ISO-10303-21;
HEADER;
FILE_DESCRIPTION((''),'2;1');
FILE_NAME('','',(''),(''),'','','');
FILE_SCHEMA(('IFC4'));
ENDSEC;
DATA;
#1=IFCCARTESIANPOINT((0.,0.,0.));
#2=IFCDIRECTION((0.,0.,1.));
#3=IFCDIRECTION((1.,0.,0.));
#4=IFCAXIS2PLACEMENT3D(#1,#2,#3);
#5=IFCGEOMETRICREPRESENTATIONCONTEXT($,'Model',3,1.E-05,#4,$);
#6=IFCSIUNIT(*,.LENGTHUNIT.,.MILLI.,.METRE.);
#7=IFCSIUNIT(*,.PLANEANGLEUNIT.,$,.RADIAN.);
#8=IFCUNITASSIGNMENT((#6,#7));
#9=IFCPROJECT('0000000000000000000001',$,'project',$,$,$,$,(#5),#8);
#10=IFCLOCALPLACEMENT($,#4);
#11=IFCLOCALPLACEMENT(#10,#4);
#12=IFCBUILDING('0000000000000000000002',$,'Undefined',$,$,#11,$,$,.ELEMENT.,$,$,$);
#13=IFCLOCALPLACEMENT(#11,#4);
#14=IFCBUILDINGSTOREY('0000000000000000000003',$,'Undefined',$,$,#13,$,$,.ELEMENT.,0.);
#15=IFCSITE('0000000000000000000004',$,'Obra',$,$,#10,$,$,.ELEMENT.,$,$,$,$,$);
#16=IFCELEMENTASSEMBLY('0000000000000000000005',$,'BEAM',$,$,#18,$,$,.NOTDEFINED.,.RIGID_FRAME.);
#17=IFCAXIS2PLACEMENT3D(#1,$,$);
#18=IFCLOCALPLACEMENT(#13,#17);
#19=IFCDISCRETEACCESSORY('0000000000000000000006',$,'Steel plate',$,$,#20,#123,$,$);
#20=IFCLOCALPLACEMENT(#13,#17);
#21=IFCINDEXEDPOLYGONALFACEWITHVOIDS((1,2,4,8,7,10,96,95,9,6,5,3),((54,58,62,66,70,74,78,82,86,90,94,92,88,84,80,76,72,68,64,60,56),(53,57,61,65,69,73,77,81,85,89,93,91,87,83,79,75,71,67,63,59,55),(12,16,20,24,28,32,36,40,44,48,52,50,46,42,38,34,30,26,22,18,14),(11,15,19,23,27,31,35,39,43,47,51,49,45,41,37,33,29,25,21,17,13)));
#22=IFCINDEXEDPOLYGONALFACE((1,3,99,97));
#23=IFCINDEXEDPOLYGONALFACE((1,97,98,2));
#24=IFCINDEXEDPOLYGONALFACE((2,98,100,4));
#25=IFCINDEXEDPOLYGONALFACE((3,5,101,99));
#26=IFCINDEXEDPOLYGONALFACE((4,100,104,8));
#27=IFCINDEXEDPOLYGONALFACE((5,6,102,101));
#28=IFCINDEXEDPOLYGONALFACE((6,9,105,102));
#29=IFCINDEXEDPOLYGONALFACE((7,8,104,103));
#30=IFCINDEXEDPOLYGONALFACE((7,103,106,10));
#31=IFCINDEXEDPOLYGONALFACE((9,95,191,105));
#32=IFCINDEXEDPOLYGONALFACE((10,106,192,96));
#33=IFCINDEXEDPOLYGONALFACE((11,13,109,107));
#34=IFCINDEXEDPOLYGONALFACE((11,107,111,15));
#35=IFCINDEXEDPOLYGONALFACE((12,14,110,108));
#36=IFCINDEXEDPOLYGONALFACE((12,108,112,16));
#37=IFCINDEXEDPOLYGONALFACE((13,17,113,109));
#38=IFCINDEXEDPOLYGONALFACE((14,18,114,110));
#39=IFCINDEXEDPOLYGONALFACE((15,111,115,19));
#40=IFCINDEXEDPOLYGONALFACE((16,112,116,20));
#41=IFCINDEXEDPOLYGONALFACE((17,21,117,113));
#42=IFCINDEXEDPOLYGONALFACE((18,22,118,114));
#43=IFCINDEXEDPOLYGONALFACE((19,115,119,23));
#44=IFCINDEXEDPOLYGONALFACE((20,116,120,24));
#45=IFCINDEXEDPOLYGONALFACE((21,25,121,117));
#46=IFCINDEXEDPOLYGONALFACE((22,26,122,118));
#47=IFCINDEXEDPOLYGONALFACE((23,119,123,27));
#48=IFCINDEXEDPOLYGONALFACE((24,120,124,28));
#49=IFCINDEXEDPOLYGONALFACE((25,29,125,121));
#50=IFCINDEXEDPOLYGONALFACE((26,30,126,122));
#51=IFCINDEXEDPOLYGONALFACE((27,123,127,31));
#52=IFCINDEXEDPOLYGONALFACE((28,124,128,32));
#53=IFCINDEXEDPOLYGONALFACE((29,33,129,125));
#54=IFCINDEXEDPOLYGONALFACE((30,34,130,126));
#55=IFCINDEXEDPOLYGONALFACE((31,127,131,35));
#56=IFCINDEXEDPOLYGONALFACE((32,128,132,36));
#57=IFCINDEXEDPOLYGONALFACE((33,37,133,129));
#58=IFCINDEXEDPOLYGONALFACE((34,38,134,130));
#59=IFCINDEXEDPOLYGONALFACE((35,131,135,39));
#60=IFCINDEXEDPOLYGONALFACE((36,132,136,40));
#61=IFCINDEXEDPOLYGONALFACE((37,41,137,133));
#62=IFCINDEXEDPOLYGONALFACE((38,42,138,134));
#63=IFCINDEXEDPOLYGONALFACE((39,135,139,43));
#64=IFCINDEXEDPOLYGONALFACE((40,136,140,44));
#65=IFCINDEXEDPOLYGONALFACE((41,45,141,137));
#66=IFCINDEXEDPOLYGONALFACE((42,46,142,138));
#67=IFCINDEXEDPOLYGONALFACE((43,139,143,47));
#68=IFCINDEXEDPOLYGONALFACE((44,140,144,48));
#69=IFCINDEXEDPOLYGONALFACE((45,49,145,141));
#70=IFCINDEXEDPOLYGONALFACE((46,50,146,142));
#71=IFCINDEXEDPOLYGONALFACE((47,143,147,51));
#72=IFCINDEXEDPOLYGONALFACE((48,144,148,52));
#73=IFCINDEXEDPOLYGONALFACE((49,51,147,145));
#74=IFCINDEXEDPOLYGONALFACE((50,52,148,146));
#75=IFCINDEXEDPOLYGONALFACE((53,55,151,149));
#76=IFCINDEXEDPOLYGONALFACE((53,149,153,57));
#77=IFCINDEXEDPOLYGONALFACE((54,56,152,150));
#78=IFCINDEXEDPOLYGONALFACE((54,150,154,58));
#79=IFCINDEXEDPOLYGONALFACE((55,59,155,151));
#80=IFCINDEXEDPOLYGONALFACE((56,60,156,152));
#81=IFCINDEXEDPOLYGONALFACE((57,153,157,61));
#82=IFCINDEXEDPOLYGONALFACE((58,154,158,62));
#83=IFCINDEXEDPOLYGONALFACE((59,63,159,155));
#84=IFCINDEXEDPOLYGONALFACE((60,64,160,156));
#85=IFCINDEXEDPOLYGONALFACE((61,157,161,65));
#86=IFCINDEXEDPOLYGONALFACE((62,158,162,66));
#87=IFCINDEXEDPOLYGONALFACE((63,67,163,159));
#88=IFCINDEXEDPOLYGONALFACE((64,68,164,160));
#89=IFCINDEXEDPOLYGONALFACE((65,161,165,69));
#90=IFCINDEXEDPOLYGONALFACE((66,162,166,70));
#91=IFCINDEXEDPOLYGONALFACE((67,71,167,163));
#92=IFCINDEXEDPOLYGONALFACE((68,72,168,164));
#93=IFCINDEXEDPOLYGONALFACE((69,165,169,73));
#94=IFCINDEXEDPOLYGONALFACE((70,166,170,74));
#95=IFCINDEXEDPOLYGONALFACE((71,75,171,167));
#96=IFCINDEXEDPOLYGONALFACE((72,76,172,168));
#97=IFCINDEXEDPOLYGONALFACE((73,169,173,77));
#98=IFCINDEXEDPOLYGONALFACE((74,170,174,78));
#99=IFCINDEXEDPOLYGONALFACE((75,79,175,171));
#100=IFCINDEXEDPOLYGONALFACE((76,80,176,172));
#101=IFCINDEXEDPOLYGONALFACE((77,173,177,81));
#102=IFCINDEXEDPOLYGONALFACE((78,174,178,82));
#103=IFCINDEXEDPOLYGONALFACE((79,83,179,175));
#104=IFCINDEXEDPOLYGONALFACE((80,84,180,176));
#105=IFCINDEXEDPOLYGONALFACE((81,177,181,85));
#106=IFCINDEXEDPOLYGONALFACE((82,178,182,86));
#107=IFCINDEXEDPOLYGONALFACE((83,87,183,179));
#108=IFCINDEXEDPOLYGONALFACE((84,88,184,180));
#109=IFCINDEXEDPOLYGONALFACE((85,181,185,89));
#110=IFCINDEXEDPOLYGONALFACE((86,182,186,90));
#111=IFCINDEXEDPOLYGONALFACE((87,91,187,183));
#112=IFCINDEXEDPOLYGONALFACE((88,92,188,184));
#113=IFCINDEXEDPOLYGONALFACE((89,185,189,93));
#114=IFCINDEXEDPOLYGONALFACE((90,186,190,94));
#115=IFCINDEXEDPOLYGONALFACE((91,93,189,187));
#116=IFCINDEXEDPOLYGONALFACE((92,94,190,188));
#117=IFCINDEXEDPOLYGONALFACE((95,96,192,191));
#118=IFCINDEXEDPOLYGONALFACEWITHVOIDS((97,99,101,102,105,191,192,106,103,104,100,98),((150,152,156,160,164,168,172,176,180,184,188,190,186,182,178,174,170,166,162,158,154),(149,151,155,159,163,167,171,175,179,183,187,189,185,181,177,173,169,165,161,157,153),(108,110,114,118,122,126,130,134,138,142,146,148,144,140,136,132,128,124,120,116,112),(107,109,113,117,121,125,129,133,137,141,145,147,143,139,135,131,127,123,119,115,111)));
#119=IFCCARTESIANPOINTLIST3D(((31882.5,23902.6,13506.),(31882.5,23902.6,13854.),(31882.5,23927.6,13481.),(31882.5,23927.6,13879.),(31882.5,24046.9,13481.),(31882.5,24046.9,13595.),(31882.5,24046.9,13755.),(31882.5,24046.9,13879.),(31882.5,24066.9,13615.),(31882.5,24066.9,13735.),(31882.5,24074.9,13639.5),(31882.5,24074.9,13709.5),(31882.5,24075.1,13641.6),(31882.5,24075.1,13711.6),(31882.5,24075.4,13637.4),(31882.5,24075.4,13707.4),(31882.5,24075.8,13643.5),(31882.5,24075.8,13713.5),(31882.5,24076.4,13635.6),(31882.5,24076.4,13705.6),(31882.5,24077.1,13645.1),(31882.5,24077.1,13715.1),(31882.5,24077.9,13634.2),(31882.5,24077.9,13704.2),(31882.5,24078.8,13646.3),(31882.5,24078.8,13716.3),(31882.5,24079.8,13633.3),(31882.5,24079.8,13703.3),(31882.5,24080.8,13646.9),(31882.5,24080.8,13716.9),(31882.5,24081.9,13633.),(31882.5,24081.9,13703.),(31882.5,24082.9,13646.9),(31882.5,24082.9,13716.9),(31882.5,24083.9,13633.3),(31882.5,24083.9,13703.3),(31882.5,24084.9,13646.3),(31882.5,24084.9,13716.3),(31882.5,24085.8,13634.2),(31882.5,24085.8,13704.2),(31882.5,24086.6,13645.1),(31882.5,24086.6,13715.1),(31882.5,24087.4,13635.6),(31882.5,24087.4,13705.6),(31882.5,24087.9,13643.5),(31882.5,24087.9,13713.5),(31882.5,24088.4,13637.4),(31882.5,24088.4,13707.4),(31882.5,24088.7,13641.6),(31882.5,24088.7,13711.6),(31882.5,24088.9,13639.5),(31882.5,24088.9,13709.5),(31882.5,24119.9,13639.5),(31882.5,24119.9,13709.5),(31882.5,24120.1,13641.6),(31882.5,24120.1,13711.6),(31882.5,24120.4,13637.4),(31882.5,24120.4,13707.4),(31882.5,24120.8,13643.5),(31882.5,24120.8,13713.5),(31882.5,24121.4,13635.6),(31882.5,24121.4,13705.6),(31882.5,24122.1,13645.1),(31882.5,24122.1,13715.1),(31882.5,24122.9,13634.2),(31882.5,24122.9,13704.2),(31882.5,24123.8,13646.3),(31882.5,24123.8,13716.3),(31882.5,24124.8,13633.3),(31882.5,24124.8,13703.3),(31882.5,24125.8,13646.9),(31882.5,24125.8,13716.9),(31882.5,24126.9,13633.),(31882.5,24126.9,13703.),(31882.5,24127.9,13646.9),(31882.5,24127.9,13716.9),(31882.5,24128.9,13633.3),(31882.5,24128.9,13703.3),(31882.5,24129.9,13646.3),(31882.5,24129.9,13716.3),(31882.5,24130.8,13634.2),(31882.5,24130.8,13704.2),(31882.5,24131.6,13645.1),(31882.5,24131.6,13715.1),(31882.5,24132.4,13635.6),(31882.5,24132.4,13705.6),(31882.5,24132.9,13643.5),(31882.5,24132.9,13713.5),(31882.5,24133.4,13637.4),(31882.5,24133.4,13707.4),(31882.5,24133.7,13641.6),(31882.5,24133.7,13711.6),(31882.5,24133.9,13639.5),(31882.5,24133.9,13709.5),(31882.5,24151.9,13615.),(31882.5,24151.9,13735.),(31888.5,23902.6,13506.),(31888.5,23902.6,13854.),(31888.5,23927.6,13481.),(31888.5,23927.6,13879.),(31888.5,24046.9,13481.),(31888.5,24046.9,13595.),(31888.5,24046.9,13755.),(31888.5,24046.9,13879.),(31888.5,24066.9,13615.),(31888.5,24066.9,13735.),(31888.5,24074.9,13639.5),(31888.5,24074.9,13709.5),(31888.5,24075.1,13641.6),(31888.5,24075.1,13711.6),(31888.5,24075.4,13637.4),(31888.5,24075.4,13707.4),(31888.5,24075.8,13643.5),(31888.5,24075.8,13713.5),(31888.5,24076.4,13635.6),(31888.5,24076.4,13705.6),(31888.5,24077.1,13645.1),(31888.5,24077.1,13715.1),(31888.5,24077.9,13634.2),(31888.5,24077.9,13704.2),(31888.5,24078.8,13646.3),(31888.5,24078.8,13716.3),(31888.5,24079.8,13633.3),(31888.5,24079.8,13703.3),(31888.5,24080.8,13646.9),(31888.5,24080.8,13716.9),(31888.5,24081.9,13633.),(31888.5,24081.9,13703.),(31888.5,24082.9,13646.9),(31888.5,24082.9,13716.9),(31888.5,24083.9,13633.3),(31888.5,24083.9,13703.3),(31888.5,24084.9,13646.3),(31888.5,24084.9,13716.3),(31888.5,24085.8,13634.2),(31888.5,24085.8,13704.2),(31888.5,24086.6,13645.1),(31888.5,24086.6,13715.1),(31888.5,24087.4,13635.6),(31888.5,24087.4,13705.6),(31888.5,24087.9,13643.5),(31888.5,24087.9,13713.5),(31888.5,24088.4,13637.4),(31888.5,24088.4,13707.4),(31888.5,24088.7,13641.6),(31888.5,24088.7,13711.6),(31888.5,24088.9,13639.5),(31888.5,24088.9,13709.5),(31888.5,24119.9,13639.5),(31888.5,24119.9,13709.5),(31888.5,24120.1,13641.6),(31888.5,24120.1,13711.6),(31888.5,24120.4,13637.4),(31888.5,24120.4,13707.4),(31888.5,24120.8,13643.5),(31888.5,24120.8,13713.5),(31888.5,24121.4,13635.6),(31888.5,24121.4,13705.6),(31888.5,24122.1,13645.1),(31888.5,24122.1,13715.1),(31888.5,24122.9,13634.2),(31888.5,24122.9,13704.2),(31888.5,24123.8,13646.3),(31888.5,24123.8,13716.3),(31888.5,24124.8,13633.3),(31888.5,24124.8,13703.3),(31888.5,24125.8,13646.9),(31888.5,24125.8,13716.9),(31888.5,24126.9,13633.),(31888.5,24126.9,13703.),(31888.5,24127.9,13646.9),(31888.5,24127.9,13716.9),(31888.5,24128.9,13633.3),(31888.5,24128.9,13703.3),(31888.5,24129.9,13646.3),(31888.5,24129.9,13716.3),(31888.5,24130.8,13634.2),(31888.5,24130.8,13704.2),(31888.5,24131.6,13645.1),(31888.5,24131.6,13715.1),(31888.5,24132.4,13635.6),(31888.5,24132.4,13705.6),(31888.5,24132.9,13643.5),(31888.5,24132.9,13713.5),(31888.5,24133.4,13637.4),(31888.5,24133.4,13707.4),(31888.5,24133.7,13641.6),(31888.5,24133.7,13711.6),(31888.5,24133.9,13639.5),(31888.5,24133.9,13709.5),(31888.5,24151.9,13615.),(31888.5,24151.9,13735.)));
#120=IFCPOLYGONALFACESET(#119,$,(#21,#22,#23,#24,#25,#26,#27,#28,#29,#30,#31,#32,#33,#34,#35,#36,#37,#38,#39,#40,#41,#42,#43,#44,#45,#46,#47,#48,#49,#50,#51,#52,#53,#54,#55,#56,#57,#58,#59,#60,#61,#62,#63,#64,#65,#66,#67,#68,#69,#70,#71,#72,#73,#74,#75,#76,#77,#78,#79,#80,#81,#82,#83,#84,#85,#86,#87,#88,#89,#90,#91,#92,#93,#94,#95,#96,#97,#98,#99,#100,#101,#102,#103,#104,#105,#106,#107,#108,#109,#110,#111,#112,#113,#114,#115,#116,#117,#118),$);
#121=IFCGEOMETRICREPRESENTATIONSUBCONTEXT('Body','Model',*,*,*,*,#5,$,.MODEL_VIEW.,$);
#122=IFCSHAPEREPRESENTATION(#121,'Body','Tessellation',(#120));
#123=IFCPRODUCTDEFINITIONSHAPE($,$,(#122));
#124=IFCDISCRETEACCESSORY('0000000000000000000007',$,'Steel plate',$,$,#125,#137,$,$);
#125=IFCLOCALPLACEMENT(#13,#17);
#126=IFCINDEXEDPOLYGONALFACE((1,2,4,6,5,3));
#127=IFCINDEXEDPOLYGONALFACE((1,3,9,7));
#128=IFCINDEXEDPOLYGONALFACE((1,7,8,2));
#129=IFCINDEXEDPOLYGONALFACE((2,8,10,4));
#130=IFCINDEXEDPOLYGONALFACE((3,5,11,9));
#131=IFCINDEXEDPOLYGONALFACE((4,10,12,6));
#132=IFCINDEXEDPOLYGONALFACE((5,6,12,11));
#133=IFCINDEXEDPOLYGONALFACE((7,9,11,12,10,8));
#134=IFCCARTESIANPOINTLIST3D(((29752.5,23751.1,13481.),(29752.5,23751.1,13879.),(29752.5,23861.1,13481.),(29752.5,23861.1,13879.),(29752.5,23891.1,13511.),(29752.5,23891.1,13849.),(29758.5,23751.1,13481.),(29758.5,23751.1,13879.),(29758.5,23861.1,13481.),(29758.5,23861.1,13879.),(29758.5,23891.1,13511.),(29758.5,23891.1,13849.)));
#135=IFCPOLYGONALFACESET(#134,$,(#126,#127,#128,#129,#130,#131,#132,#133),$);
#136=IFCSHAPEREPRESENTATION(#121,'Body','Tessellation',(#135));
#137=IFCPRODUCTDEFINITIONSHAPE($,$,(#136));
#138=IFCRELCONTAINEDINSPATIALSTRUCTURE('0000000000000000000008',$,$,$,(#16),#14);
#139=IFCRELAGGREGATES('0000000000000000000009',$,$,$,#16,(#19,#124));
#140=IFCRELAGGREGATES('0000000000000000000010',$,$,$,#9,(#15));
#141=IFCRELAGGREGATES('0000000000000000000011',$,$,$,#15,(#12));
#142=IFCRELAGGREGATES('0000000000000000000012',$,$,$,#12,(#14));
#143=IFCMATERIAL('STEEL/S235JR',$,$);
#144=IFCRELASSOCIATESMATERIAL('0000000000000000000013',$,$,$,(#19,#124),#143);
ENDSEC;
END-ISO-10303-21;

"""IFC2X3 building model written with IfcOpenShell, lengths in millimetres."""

from ifc_helpers import new_model, si_unit, frame, origin_with_axes, origin_2d_with_axis, place, context, subcontext, project, spatial, polyline, circle, outline, extrude, source, transform, mapped, material, element, aggregate, save


model = new_model("IFC2X3")

# Units and contexts
model_context = context("Model", 3, precision=1e-05, world=origin_with_axes())
body_context = subcontext(model_context, "Body", "Model", "MODEL_VIEW")
ifc_project = project(units=[si_unit("LENGTHUNIT", "METRE", prefix="MILLI"), si_unit("PLANEANGLEUNIT", "RADIAN")], contexts=[model_context])

# Site, building, storey
site_placement = place(None, origin_with_axes())
site = spatial("IfcSite", under=ifc_project, at=site_placement, Name="Obra", CompositionType="ELEMENT")
building_placement = place(site_placement, origin_with_axes())
building = spatial("IfcBuilding", under=site, at=building_placement, Name="Undefined", CompositionType="ELEMENT")
storey_placement = place(building_placement, origin_with_axes())
storey = spatial("IfcBuildingStorey", under=building, at=storey_placement, Name="Undefined", CompositionType="ELEMENT", Elevation=0.0)

# Shared definitions
ifc_material_1 = material(Name="STEEL/S235JR")

# Element assembly, discrete accessories, opening
assembly_1_placement = place(storey_placement, origin_with_axes())
assembly_1 = element("IfcElementAssembly", 1, at=assembly_1_placement, inside=storey, Name="BEAM", AssemblyPlace="NOTDEFINED", PredefinedType="RIGID_FRAME")
discrete_accessory_1_placement = place(assembly_1_placement, frame((31885.5, 23902.6, 13506.0), z_axis=(1.0, 0.0, 0.0), x_axis=(-0.000001, 0.707107, -0.707107)))
discrete_accessory_1 = element("IfcDiscreteAccessory", 2, at=discrete_accessory_1_placement, material=ifc_material_1, Name="Steel plate", context=body_context, shape_type="SweptSolid", body=[
    extrude(outline(polyline([(0.0, 0.0), (35.4, 0.0), (119.7, 84.3), (39.1, 164.9), (39.1, 193.2), (99.2, 253.3), (14.3, 338.2), (-45.8, 278.1), (-74.1, 278.1), (-161.8, 365.8), (-246.1, 281.4), (-246.1, 246.1), (0.0, 0.0)])), frame((0.0, 0.0, -3.0), z_axis=(0.0, 0.0, 1.0), x_axis=(1.0, 0.0, 0.0)), (0.0, 0.0, 1.0), 6.0),
])
shared_shape_1 = source(origin_with_axes(), body_context, "Body", "SweptSolid", [
    extrude(circle(Radius=7.0, at=origin_2d_with_axis()), frame((0.0, -8.6, 0.0), z_axis=(0.0, 1.0, 0.0), x_axis=(1.0, 0.0, 0.0)), (0.0, 0.0, 1.0), 6.2),
])
opening_1_placement = place(assembly_1_placement, frame((31880.0, 24056.9, 13735.0), z_axis=(0.0, 1.0, 0.0), x_axis=(0.0, 0.0, -1.0)))
element("IfcOpeningElement", 3, at=opening_1_placement, cuts=discrete_accessory_1, ObjectType="Opening", context=body_context, shape_type="MappedRepresentation", body=[
    mapped(shared_shape_1, transform((25.0, 0.0, 25.0))),
    mapped(shared_shape_1, transform((25.0, 0.0, 70.0))),
    mapped(shared_shape_1, transform((95.0, 0.0, 25.0))),
    mapped(shared_shape_1, transform((95.0, 0.0, 70.0))),
])
discrete_accessory_2_placement = place(assembly_1_placement, frame((29755.5, 23891.1, 13481.0), z_axis=(-1.0, 0.0, 0.0), x_axis=(0.0, -1.0, 0.0)))
discrete_accessory_2 = element("IfcDiscreteAccessory", 4, at=discrete_accessory_2_placement, material=ifc_material_1, Name="Steel plate", context=body_context, shape_type="SweptSolid", body=[
    extrude(outline(polyline([(0.0, 30.0), (30.0, 0.0), (140.0, 0.0), (140.0, 398.0), (30.0, 398.0), (0.0, 368.0), (0.0, 30.0)])), frame((0.0, 0.0, -3.0), z_axis=(0.0, 0.0, 1.0), x_axis=(1.0, 0.0, 0.0)), (0.0, 0.0, 1.0), 6.0),
])
aggregate(assembly_1, [discrete_accessory_1, discrete_accessory_2])

save(model, "model.ifc")
